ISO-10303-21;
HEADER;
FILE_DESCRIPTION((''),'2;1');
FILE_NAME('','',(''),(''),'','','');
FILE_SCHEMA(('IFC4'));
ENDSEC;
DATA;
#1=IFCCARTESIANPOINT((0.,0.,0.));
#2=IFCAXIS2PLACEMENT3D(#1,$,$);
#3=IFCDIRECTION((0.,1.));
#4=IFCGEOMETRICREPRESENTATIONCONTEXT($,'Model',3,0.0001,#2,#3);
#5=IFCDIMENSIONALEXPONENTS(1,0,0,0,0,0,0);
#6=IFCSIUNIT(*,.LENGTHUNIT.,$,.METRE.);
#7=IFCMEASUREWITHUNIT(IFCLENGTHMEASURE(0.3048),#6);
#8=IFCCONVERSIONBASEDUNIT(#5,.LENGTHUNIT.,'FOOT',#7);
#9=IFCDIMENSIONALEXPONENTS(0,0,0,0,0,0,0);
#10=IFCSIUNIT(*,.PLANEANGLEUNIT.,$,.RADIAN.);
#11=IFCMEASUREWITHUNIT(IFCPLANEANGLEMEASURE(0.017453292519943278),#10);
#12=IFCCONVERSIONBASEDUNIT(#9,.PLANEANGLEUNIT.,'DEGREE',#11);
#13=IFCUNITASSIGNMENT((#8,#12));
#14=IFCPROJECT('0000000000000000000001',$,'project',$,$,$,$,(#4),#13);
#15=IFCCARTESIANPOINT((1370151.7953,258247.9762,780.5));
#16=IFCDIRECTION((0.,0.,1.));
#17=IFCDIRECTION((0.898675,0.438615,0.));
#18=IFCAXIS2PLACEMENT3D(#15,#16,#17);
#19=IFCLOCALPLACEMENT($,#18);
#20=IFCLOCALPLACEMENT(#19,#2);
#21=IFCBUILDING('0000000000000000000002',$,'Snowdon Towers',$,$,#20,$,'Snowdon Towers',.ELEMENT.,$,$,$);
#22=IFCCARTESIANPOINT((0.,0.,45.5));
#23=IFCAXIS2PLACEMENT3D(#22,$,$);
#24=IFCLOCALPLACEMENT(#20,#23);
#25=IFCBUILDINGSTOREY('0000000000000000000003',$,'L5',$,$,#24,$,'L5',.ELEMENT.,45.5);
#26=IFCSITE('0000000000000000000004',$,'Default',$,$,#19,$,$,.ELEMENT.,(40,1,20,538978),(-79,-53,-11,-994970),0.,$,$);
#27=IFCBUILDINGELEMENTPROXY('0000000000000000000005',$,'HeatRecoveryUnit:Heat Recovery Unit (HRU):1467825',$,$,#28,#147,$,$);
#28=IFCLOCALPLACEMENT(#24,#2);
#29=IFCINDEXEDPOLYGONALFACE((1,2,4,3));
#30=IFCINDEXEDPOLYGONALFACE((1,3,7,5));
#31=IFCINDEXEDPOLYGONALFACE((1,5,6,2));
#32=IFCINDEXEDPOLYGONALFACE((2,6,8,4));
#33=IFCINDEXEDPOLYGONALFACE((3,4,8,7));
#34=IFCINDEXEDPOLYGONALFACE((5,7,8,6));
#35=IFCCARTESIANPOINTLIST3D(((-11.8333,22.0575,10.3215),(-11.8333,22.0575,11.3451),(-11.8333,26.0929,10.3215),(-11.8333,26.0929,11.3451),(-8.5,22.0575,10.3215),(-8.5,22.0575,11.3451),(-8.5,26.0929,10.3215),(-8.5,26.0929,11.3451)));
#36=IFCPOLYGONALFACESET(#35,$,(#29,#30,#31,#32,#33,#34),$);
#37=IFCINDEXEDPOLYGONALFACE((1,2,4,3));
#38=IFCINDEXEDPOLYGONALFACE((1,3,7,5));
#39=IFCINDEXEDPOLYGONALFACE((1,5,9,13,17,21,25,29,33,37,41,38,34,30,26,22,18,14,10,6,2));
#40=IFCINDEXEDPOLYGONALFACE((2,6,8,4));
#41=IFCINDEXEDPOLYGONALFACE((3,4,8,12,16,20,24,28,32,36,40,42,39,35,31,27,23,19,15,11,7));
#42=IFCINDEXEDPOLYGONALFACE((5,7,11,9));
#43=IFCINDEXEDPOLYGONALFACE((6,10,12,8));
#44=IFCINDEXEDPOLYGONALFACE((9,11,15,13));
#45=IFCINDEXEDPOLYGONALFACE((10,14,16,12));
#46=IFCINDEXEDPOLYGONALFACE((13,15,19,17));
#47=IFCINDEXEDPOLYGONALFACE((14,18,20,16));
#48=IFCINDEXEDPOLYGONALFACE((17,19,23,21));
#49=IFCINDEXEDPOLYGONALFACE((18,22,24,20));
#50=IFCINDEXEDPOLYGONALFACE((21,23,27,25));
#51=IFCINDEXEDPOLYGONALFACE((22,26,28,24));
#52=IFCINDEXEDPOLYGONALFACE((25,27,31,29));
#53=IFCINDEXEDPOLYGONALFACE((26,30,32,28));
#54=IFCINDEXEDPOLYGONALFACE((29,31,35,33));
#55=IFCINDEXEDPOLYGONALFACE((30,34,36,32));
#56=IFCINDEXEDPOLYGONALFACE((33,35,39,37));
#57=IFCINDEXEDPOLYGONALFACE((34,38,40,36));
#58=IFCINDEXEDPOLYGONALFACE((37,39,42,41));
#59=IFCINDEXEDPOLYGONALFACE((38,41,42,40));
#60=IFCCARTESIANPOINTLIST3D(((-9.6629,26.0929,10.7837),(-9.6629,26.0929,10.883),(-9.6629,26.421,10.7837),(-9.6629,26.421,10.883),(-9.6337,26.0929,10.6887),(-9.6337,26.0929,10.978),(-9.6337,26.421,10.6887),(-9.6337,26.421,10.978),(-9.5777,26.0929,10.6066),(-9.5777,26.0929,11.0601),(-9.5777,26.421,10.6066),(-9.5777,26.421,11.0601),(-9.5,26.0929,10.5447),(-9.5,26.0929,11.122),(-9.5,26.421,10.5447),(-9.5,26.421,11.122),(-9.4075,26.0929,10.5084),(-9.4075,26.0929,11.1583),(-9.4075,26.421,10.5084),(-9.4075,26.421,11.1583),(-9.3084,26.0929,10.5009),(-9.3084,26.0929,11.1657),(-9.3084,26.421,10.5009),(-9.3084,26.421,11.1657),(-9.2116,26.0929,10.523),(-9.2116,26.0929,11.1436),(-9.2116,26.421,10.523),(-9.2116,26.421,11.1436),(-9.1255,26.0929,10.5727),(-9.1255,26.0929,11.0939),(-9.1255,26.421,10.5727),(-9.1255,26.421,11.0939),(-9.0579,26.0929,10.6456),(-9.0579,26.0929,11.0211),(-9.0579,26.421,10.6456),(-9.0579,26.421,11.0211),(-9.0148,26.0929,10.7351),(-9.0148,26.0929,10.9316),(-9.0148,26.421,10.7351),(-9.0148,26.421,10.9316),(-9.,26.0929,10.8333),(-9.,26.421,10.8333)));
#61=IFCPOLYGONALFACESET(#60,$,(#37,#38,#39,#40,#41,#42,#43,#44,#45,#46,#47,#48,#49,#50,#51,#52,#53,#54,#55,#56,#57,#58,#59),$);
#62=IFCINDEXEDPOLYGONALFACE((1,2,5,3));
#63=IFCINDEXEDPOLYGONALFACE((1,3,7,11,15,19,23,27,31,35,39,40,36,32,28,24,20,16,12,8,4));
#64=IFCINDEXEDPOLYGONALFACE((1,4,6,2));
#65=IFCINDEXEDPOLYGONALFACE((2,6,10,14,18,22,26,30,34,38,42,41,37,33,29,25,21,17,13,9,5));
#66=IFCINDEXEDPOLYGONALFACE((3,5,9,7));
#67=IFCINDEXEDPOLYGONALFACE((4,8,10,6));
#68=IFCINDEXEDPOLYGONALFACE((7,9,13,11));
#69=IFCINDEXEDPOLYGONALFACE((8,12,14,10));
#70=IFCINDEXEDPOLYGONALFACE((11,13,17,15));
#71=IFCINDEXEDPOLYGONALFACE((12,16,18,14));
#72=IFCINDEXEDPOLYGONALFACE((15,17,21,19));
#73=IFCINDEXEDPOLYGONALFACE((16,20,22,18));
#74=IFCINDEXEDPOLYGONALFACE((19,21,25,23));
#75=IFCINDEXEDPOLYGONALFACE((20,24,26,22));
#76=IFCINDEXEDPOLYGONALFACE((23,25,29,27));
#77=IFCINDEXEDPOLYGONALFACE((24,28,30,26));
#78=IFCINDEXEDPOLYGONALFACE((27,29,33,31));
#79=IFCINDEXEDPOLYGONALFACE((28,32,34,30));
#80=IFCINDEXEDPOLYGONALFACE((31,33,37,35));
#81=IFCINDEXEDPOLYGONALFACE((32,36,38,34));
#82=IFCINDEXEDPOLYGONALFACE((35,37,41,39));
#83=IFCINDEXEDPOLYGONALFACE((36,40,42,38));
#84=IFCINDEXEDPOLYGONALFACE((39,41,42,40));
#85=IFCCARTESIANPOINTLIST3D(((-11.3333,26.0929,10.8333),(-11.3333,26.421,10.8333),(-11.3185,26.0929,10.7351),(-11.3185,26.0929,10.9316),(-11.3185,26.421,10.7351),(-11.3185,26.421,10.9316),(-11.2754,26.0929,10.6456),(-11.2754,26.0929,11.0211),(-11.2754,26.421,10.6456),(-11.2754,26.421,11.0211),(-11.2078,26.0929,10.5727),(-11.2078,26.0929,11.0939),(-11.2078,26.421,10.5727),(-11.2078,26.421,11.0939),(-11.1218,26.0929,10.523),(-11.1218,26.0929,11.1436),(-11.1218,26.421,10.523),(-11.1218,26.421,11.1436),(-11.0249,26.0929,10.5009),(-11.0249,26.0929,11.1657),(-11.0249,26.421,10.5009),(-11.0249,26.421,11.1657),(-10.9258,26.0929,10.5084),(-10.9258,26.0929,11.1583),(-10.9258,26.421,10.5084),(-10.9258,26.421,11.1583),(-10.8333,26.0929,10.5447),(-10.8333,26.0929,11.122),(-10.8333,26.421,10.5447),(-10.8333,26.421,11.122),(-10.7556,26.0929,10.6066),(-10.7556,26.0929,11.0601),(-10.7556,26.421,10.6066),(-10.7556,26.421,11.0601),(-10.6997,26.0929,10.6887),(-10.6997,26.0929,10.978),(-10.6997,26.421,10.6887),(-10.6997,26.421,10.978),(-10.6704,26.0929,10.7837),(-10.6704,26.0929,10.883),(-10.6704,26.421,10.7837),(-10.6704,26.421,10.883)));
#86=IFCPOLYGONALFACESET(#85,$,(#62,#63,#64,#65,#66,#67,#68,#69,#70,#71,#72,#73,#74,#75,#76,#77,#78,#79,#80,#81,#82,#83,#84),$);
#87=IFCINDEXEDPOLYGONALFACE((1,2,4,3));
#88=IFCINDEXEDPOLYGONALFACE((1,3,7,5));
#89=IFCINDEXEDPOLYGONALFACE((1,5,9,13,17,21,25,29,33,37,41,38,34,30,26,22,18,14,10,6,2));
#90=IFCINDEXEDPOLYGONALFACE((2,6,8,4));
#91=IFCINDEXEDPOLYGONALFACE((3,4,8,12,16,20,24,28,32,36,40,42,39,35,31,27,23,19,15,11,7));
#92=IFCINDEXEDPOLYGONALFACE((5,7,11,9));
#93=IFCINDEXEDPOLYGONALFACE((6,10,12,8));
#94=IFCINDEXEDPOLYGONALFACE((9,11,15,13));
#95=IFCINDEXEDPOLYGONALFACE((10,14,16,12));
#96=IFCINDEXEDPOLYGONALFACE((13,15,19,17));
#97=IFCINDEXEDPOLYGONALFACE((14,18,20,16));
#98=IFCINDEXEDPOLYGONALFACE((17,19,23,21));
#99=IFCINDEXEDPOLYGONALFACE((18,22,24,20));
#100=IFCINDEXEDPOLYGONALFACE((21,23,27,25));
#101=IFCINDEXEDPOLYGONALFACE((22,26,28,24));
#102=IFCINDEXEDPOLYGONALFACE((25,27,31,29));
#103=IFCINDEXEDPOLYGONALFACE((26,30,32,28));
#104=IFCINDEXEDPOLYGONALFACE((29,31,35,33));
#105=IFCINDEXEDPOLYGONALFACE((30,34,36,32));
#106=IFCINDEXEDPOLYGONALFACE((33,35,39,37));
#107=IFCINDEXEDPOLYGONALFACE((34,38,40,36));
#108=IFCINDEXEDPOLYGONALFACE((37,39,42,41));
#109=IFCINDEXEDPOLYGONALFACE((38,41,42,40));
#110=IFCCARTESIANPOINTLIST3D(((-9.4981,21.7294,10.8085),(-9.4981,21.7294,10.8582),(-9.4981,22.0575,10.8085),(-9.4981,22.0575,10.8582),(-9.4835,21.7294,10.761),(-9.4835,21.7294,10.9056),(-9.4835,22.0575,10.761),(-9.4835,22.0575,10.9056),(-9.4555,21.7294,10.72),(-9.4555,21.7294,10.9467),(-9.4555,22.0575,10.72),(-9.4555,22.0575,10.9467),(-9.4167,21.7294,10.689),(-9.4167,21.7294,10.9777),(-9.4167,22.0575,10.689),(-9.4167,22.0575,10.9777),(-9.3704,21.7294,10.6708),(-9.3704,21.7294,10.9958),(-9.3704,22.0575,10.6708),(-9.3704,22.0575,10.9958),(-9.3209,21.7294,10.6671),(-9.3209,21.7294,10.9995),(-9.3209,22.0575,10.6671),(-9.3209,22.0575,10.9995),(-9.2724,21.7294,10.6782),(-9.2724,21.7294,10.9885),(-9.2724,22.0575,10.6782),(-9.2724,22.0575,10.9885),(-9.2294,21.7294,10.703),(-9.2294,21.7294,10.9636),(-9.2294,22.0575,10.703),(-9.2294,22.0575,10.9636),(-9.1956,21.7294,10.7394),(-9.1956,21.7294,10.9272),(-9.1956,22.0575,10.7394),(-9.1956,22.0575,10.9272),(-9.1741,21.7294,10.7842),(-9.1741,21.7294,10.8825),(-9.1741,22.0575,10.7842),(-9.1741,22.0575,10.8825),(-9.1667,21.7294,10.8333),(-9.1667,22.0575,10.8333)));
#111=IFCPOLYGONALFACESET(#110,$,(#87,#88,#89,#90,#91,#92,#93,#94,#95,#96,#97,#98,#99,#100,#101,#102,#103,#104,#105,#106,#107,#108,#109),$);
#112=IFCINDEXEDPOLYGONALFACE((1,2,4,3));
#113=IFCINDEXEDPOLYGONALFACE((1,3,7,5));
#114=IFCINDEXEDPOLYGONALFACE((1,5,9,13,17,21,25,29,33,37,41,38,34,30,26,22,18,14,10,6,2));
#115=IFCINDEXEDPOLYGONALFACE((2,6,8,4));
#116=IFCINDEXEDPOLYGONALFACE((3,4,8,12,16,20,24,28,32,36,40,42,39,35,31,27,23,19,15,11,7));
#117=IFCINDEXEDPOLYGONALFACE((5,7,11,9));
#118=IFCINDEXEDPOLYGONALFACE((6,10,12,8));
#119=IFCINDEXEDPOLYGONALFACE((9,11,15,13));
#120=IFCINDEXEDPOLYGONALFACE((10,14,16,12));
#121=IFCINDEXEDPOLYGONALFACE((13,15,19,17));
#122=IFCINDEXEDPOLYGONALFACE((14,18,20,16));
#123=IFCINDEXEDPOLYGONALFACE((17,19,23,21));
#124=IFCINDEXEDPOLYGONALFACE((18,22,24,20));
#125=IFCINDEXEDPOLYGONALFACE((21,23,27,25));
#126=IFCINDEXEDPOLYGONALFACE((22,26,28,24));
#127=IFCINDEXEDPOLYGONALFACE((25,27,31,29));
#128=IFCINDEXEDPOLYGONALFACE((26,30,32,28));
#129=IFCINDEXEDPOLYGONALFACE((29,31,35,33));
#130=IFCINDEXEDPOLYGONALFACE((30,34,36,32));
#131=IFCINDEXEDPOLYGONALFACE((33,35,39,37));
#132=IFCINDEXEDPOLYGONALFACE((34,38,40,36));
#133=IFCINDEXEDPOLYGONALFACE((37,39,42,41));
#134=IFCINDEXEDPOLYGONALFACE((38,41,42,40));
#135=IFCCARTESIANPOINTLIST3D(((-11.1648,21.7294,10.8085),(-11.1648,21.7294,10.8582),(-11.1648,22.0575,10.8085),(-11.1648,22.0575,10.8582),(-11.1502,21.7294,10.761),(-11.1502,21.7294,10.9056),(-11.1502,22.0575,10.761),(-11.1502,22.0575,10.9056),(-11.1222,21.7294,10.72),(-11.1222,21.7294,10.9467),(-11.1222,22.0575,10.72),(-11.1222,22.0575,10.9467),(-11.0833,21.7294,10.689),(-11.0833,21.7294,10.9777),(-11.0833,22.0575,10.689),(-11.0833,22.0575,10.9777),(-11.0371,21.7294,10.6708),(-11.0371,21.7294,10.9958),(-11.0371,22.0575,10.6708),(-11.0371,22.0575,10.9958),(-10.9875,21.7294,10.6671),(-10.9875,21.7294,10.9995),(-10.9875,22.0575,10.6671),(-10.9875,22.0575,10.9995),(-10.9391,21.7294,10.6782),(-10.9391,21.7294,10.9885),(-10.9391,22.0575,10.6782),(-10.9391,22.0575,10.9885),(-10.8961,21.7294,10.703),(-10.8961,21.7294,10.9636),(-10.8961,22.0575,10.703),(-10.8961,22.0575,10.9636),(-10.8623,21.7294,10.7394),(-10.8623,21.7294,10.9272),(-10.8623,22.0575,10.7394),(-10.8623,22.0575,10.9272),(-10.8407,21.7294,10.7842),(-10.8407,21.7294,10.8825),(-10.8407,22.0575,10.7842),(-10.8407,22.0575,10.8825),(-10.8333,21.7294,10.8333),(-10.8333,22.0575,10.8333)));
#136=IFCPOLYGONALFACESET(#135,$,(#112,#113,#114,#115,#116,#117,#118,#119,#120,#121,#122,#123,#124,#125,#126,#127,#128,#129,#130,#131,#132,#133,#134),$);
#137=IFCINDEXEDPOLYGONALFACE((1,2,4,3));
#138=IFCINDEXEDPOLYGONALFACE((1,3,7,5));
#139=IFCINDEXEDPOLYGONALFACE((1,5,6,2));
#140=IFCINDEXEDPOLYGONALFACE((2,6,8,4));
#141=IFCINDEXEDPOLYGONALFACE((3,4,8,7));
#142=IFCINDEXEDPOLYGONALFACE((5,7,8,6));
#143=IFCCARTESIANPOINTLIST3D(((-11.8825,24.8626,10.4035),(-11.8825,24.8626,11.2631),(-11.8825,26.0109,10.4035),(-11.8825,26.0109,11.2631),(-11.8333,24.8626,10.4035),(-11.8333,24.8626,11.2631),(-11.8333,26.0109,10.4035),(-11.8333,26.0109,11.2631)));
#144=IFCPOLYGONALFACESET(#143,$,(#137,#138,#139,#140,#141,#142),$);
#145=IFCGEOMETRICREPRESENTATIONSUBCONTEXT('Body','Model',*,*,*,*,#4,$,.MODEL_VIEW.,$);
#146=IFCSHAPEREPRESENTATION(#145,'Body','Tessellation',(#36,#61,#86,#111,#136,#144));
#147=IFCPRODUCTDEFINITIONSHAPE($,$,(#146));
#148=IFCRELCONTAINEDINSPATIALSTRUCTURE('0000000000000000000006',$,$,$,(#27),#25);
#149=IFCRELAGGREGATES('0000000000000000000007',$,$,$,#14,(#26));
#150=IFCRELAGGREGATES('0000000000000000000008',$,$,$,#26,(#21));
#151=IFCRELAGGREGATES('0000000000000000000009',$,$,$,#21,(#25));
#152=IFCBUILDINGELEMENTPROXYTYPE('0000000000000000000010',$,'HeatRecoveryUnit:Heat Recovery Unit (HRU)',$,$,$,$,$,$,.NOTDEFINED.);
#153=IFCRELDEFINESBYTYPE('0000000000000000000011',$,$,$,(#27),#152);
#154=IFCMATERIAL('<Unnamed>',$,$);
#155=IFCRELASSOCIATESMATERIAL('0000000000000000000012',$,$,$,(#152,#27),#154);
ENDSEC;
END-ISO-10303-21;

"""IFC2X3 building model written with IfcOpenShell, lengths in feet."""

from ifc_helpers import new_model, entity, si_unit, converted_unit, direction, frame, frame_2d, origin, origin_2d_with_axis, place, context, subcontext, project, spatial, rectangle, circle, extrude, source, transform, mapped, material, type_object, type_shapes, element, save


model = new_model("IFC2X3")

# Units and contexts
model_context = context("Model", 3, precision=0.0001, world=origin(), true_north=direction((0.0, 1.0)))
body_context = subcontext(model_context, "Body", "Model", "MODEL_VIEW")
ifc_project = project(units=[converted_unit("LENGTHUNIT", "FOOT", entity("IfcLengthMeasure", 0.3048), si_unit("LENGTHUNIT", "METRE"), dimensions=[1, 0, 0, 0, 0, 0, 0]), converted_unit("PLANEANGLEUNIT", "DEGREE", entity("IfcPlaneAngleMeasure", 0.017453292519943278), si_unit("PLANEANGLEUNIT", "RADIAN"), dimensions=[0, 0, 0, 0, 0, 0, 0])], contexts=[model_context])

# Site, building, storey
site_placement = place(None, frame((1370151.7953, 258247.9762, 780.5), z_axis=(0.0, 0.0, 1.0), x_axis=(0.898675, 0.438615, 0.0)))
site = spatial("IfcSite", under=ifc_project, at=site_placement, Name="Default", CompositionType="ELEMENT", RefLatitude=(40, 1, 20, 538978), RefLongitude=(-79, -53, -11, -994970), RefElevation=0.0)
building_placement = place(site_placement, origin())
building = spatial("IfcBuilding", under=site, at=building_placement, Name="Snowdon Towers", LongName="Snowdon Towers", CompositionType="ELEMENT")
storey_placement = place(building_placement, frame((0.0, 0.0, 45.5)))
storey = spatial("IfcBuildingStorey", under=building, at=storey_placement, Name="L5", LongName="L5", CompositionType="ELEMENT", Elevation=45.5)

# Shared definitions
ifc_material = material(Name="<Unnamed>")

# Building element proxy
building_element_proxy_type = type_object("IfcBuildingElementProxyType", Name="HeatRecoveryUnit:Heat Recovery Unit (HRU)", PredefinedType="NOTDEFINED", material=ifc_material)
shared_shape_1 = source(origin(), body_context, "Body", "SweptSolid", [
    extrude(rectangle(XDim=3.3333, YDim=4.0354, at=origin_2d_with_axis()), frame((0.0, 0.0, 0.0), z_axis=(0.0, 0.0, 1.0), x_axis=(-1.0, 0.0, 0.0)), (0.0, 0.0, 1.0), 1.0236),
    extrude(circle(Radius=0.3333, at=frame_2d((0.0, 0.0), x_axis=(1.0, 0.0))), frame((-0.8333, -2.3458, 0.5118), z_axis=(0.0, 1.0, 0.0), x_axis=(-1.0, 0.0, 0.0)), (0.0, 0.0, 1.0), 0.3281),
    extrude(circle(Radius=0.3333, at=frame_2d((0.0, 0.0), x_axis=(1.0, 0.0))), frame((0.8333, -2.3458, 0.5118), z_axis=(0.0, 1.0, 0.0), x_axis=(1.0, 0.0, 0.0)), (0.0, 0.0, 1.0), 0.3281),
    extrude(circle(Radius=0.1667, at=frame_2d((0.0, 0.0), x_axis=(1.0, 0.0))), frame((-0.8333, 2.0177, 0.5118), z_axis=(0.0, 1.0, 0.0), x_axis=(-1.0, 0.0, 0.0)), (0.0, 0.0, 1.0), 0.3281),
    extrude(circle(Radius=0.1667, at=frame_2d((0.0, 0.0), x_axis=(1.0, 0.0))), frame((0.8333, 2.0177, 0.5118), z_axis=(0.0, 1.0, 0.0), x_axis=(-1.0, 0.0, 0.0)), (0.0, 0.0, 1.0), 0.3281),
    extrude(rectangle(XDim=0.0492, YDim=1.1483, at=origin_2d_with_axis()), frame((1.6913, -1.3615, 0.082), z_axis=(0.0, 0.0, 1.0), x_axis=(-1.0, 0.0, 0.0)), (0.0, 0.0, 1.0), 0.8596),
])
type_shapes(building_element_proxy_type, [shared_shape_1])
for number, where, z_axis, x_axis, name in (
    (1, (-10.1667, 24.0752, 10.3215), (0.0, 0.0, 1.0), (-1.0, 0.0, 0.0), "HeatRecoveryUnit:Heat Recovery Unit (HRU):1467825"),
):
    element("IfcBuildingElementProxy", number, at=place(storey_placement, frame(where, z_axis=z_axis, x_axis=x_axis)), inside=storey, type_object=building_element_proxy_type, material=ifc_material, Name=name, context=body_context, shape_type="MappedRepresentation", body=[
        mapped(shared_shape_1, transform((0.0, 0.0, 0.0), scale=1.0)),
    ])

save(model, "model.ifc")
